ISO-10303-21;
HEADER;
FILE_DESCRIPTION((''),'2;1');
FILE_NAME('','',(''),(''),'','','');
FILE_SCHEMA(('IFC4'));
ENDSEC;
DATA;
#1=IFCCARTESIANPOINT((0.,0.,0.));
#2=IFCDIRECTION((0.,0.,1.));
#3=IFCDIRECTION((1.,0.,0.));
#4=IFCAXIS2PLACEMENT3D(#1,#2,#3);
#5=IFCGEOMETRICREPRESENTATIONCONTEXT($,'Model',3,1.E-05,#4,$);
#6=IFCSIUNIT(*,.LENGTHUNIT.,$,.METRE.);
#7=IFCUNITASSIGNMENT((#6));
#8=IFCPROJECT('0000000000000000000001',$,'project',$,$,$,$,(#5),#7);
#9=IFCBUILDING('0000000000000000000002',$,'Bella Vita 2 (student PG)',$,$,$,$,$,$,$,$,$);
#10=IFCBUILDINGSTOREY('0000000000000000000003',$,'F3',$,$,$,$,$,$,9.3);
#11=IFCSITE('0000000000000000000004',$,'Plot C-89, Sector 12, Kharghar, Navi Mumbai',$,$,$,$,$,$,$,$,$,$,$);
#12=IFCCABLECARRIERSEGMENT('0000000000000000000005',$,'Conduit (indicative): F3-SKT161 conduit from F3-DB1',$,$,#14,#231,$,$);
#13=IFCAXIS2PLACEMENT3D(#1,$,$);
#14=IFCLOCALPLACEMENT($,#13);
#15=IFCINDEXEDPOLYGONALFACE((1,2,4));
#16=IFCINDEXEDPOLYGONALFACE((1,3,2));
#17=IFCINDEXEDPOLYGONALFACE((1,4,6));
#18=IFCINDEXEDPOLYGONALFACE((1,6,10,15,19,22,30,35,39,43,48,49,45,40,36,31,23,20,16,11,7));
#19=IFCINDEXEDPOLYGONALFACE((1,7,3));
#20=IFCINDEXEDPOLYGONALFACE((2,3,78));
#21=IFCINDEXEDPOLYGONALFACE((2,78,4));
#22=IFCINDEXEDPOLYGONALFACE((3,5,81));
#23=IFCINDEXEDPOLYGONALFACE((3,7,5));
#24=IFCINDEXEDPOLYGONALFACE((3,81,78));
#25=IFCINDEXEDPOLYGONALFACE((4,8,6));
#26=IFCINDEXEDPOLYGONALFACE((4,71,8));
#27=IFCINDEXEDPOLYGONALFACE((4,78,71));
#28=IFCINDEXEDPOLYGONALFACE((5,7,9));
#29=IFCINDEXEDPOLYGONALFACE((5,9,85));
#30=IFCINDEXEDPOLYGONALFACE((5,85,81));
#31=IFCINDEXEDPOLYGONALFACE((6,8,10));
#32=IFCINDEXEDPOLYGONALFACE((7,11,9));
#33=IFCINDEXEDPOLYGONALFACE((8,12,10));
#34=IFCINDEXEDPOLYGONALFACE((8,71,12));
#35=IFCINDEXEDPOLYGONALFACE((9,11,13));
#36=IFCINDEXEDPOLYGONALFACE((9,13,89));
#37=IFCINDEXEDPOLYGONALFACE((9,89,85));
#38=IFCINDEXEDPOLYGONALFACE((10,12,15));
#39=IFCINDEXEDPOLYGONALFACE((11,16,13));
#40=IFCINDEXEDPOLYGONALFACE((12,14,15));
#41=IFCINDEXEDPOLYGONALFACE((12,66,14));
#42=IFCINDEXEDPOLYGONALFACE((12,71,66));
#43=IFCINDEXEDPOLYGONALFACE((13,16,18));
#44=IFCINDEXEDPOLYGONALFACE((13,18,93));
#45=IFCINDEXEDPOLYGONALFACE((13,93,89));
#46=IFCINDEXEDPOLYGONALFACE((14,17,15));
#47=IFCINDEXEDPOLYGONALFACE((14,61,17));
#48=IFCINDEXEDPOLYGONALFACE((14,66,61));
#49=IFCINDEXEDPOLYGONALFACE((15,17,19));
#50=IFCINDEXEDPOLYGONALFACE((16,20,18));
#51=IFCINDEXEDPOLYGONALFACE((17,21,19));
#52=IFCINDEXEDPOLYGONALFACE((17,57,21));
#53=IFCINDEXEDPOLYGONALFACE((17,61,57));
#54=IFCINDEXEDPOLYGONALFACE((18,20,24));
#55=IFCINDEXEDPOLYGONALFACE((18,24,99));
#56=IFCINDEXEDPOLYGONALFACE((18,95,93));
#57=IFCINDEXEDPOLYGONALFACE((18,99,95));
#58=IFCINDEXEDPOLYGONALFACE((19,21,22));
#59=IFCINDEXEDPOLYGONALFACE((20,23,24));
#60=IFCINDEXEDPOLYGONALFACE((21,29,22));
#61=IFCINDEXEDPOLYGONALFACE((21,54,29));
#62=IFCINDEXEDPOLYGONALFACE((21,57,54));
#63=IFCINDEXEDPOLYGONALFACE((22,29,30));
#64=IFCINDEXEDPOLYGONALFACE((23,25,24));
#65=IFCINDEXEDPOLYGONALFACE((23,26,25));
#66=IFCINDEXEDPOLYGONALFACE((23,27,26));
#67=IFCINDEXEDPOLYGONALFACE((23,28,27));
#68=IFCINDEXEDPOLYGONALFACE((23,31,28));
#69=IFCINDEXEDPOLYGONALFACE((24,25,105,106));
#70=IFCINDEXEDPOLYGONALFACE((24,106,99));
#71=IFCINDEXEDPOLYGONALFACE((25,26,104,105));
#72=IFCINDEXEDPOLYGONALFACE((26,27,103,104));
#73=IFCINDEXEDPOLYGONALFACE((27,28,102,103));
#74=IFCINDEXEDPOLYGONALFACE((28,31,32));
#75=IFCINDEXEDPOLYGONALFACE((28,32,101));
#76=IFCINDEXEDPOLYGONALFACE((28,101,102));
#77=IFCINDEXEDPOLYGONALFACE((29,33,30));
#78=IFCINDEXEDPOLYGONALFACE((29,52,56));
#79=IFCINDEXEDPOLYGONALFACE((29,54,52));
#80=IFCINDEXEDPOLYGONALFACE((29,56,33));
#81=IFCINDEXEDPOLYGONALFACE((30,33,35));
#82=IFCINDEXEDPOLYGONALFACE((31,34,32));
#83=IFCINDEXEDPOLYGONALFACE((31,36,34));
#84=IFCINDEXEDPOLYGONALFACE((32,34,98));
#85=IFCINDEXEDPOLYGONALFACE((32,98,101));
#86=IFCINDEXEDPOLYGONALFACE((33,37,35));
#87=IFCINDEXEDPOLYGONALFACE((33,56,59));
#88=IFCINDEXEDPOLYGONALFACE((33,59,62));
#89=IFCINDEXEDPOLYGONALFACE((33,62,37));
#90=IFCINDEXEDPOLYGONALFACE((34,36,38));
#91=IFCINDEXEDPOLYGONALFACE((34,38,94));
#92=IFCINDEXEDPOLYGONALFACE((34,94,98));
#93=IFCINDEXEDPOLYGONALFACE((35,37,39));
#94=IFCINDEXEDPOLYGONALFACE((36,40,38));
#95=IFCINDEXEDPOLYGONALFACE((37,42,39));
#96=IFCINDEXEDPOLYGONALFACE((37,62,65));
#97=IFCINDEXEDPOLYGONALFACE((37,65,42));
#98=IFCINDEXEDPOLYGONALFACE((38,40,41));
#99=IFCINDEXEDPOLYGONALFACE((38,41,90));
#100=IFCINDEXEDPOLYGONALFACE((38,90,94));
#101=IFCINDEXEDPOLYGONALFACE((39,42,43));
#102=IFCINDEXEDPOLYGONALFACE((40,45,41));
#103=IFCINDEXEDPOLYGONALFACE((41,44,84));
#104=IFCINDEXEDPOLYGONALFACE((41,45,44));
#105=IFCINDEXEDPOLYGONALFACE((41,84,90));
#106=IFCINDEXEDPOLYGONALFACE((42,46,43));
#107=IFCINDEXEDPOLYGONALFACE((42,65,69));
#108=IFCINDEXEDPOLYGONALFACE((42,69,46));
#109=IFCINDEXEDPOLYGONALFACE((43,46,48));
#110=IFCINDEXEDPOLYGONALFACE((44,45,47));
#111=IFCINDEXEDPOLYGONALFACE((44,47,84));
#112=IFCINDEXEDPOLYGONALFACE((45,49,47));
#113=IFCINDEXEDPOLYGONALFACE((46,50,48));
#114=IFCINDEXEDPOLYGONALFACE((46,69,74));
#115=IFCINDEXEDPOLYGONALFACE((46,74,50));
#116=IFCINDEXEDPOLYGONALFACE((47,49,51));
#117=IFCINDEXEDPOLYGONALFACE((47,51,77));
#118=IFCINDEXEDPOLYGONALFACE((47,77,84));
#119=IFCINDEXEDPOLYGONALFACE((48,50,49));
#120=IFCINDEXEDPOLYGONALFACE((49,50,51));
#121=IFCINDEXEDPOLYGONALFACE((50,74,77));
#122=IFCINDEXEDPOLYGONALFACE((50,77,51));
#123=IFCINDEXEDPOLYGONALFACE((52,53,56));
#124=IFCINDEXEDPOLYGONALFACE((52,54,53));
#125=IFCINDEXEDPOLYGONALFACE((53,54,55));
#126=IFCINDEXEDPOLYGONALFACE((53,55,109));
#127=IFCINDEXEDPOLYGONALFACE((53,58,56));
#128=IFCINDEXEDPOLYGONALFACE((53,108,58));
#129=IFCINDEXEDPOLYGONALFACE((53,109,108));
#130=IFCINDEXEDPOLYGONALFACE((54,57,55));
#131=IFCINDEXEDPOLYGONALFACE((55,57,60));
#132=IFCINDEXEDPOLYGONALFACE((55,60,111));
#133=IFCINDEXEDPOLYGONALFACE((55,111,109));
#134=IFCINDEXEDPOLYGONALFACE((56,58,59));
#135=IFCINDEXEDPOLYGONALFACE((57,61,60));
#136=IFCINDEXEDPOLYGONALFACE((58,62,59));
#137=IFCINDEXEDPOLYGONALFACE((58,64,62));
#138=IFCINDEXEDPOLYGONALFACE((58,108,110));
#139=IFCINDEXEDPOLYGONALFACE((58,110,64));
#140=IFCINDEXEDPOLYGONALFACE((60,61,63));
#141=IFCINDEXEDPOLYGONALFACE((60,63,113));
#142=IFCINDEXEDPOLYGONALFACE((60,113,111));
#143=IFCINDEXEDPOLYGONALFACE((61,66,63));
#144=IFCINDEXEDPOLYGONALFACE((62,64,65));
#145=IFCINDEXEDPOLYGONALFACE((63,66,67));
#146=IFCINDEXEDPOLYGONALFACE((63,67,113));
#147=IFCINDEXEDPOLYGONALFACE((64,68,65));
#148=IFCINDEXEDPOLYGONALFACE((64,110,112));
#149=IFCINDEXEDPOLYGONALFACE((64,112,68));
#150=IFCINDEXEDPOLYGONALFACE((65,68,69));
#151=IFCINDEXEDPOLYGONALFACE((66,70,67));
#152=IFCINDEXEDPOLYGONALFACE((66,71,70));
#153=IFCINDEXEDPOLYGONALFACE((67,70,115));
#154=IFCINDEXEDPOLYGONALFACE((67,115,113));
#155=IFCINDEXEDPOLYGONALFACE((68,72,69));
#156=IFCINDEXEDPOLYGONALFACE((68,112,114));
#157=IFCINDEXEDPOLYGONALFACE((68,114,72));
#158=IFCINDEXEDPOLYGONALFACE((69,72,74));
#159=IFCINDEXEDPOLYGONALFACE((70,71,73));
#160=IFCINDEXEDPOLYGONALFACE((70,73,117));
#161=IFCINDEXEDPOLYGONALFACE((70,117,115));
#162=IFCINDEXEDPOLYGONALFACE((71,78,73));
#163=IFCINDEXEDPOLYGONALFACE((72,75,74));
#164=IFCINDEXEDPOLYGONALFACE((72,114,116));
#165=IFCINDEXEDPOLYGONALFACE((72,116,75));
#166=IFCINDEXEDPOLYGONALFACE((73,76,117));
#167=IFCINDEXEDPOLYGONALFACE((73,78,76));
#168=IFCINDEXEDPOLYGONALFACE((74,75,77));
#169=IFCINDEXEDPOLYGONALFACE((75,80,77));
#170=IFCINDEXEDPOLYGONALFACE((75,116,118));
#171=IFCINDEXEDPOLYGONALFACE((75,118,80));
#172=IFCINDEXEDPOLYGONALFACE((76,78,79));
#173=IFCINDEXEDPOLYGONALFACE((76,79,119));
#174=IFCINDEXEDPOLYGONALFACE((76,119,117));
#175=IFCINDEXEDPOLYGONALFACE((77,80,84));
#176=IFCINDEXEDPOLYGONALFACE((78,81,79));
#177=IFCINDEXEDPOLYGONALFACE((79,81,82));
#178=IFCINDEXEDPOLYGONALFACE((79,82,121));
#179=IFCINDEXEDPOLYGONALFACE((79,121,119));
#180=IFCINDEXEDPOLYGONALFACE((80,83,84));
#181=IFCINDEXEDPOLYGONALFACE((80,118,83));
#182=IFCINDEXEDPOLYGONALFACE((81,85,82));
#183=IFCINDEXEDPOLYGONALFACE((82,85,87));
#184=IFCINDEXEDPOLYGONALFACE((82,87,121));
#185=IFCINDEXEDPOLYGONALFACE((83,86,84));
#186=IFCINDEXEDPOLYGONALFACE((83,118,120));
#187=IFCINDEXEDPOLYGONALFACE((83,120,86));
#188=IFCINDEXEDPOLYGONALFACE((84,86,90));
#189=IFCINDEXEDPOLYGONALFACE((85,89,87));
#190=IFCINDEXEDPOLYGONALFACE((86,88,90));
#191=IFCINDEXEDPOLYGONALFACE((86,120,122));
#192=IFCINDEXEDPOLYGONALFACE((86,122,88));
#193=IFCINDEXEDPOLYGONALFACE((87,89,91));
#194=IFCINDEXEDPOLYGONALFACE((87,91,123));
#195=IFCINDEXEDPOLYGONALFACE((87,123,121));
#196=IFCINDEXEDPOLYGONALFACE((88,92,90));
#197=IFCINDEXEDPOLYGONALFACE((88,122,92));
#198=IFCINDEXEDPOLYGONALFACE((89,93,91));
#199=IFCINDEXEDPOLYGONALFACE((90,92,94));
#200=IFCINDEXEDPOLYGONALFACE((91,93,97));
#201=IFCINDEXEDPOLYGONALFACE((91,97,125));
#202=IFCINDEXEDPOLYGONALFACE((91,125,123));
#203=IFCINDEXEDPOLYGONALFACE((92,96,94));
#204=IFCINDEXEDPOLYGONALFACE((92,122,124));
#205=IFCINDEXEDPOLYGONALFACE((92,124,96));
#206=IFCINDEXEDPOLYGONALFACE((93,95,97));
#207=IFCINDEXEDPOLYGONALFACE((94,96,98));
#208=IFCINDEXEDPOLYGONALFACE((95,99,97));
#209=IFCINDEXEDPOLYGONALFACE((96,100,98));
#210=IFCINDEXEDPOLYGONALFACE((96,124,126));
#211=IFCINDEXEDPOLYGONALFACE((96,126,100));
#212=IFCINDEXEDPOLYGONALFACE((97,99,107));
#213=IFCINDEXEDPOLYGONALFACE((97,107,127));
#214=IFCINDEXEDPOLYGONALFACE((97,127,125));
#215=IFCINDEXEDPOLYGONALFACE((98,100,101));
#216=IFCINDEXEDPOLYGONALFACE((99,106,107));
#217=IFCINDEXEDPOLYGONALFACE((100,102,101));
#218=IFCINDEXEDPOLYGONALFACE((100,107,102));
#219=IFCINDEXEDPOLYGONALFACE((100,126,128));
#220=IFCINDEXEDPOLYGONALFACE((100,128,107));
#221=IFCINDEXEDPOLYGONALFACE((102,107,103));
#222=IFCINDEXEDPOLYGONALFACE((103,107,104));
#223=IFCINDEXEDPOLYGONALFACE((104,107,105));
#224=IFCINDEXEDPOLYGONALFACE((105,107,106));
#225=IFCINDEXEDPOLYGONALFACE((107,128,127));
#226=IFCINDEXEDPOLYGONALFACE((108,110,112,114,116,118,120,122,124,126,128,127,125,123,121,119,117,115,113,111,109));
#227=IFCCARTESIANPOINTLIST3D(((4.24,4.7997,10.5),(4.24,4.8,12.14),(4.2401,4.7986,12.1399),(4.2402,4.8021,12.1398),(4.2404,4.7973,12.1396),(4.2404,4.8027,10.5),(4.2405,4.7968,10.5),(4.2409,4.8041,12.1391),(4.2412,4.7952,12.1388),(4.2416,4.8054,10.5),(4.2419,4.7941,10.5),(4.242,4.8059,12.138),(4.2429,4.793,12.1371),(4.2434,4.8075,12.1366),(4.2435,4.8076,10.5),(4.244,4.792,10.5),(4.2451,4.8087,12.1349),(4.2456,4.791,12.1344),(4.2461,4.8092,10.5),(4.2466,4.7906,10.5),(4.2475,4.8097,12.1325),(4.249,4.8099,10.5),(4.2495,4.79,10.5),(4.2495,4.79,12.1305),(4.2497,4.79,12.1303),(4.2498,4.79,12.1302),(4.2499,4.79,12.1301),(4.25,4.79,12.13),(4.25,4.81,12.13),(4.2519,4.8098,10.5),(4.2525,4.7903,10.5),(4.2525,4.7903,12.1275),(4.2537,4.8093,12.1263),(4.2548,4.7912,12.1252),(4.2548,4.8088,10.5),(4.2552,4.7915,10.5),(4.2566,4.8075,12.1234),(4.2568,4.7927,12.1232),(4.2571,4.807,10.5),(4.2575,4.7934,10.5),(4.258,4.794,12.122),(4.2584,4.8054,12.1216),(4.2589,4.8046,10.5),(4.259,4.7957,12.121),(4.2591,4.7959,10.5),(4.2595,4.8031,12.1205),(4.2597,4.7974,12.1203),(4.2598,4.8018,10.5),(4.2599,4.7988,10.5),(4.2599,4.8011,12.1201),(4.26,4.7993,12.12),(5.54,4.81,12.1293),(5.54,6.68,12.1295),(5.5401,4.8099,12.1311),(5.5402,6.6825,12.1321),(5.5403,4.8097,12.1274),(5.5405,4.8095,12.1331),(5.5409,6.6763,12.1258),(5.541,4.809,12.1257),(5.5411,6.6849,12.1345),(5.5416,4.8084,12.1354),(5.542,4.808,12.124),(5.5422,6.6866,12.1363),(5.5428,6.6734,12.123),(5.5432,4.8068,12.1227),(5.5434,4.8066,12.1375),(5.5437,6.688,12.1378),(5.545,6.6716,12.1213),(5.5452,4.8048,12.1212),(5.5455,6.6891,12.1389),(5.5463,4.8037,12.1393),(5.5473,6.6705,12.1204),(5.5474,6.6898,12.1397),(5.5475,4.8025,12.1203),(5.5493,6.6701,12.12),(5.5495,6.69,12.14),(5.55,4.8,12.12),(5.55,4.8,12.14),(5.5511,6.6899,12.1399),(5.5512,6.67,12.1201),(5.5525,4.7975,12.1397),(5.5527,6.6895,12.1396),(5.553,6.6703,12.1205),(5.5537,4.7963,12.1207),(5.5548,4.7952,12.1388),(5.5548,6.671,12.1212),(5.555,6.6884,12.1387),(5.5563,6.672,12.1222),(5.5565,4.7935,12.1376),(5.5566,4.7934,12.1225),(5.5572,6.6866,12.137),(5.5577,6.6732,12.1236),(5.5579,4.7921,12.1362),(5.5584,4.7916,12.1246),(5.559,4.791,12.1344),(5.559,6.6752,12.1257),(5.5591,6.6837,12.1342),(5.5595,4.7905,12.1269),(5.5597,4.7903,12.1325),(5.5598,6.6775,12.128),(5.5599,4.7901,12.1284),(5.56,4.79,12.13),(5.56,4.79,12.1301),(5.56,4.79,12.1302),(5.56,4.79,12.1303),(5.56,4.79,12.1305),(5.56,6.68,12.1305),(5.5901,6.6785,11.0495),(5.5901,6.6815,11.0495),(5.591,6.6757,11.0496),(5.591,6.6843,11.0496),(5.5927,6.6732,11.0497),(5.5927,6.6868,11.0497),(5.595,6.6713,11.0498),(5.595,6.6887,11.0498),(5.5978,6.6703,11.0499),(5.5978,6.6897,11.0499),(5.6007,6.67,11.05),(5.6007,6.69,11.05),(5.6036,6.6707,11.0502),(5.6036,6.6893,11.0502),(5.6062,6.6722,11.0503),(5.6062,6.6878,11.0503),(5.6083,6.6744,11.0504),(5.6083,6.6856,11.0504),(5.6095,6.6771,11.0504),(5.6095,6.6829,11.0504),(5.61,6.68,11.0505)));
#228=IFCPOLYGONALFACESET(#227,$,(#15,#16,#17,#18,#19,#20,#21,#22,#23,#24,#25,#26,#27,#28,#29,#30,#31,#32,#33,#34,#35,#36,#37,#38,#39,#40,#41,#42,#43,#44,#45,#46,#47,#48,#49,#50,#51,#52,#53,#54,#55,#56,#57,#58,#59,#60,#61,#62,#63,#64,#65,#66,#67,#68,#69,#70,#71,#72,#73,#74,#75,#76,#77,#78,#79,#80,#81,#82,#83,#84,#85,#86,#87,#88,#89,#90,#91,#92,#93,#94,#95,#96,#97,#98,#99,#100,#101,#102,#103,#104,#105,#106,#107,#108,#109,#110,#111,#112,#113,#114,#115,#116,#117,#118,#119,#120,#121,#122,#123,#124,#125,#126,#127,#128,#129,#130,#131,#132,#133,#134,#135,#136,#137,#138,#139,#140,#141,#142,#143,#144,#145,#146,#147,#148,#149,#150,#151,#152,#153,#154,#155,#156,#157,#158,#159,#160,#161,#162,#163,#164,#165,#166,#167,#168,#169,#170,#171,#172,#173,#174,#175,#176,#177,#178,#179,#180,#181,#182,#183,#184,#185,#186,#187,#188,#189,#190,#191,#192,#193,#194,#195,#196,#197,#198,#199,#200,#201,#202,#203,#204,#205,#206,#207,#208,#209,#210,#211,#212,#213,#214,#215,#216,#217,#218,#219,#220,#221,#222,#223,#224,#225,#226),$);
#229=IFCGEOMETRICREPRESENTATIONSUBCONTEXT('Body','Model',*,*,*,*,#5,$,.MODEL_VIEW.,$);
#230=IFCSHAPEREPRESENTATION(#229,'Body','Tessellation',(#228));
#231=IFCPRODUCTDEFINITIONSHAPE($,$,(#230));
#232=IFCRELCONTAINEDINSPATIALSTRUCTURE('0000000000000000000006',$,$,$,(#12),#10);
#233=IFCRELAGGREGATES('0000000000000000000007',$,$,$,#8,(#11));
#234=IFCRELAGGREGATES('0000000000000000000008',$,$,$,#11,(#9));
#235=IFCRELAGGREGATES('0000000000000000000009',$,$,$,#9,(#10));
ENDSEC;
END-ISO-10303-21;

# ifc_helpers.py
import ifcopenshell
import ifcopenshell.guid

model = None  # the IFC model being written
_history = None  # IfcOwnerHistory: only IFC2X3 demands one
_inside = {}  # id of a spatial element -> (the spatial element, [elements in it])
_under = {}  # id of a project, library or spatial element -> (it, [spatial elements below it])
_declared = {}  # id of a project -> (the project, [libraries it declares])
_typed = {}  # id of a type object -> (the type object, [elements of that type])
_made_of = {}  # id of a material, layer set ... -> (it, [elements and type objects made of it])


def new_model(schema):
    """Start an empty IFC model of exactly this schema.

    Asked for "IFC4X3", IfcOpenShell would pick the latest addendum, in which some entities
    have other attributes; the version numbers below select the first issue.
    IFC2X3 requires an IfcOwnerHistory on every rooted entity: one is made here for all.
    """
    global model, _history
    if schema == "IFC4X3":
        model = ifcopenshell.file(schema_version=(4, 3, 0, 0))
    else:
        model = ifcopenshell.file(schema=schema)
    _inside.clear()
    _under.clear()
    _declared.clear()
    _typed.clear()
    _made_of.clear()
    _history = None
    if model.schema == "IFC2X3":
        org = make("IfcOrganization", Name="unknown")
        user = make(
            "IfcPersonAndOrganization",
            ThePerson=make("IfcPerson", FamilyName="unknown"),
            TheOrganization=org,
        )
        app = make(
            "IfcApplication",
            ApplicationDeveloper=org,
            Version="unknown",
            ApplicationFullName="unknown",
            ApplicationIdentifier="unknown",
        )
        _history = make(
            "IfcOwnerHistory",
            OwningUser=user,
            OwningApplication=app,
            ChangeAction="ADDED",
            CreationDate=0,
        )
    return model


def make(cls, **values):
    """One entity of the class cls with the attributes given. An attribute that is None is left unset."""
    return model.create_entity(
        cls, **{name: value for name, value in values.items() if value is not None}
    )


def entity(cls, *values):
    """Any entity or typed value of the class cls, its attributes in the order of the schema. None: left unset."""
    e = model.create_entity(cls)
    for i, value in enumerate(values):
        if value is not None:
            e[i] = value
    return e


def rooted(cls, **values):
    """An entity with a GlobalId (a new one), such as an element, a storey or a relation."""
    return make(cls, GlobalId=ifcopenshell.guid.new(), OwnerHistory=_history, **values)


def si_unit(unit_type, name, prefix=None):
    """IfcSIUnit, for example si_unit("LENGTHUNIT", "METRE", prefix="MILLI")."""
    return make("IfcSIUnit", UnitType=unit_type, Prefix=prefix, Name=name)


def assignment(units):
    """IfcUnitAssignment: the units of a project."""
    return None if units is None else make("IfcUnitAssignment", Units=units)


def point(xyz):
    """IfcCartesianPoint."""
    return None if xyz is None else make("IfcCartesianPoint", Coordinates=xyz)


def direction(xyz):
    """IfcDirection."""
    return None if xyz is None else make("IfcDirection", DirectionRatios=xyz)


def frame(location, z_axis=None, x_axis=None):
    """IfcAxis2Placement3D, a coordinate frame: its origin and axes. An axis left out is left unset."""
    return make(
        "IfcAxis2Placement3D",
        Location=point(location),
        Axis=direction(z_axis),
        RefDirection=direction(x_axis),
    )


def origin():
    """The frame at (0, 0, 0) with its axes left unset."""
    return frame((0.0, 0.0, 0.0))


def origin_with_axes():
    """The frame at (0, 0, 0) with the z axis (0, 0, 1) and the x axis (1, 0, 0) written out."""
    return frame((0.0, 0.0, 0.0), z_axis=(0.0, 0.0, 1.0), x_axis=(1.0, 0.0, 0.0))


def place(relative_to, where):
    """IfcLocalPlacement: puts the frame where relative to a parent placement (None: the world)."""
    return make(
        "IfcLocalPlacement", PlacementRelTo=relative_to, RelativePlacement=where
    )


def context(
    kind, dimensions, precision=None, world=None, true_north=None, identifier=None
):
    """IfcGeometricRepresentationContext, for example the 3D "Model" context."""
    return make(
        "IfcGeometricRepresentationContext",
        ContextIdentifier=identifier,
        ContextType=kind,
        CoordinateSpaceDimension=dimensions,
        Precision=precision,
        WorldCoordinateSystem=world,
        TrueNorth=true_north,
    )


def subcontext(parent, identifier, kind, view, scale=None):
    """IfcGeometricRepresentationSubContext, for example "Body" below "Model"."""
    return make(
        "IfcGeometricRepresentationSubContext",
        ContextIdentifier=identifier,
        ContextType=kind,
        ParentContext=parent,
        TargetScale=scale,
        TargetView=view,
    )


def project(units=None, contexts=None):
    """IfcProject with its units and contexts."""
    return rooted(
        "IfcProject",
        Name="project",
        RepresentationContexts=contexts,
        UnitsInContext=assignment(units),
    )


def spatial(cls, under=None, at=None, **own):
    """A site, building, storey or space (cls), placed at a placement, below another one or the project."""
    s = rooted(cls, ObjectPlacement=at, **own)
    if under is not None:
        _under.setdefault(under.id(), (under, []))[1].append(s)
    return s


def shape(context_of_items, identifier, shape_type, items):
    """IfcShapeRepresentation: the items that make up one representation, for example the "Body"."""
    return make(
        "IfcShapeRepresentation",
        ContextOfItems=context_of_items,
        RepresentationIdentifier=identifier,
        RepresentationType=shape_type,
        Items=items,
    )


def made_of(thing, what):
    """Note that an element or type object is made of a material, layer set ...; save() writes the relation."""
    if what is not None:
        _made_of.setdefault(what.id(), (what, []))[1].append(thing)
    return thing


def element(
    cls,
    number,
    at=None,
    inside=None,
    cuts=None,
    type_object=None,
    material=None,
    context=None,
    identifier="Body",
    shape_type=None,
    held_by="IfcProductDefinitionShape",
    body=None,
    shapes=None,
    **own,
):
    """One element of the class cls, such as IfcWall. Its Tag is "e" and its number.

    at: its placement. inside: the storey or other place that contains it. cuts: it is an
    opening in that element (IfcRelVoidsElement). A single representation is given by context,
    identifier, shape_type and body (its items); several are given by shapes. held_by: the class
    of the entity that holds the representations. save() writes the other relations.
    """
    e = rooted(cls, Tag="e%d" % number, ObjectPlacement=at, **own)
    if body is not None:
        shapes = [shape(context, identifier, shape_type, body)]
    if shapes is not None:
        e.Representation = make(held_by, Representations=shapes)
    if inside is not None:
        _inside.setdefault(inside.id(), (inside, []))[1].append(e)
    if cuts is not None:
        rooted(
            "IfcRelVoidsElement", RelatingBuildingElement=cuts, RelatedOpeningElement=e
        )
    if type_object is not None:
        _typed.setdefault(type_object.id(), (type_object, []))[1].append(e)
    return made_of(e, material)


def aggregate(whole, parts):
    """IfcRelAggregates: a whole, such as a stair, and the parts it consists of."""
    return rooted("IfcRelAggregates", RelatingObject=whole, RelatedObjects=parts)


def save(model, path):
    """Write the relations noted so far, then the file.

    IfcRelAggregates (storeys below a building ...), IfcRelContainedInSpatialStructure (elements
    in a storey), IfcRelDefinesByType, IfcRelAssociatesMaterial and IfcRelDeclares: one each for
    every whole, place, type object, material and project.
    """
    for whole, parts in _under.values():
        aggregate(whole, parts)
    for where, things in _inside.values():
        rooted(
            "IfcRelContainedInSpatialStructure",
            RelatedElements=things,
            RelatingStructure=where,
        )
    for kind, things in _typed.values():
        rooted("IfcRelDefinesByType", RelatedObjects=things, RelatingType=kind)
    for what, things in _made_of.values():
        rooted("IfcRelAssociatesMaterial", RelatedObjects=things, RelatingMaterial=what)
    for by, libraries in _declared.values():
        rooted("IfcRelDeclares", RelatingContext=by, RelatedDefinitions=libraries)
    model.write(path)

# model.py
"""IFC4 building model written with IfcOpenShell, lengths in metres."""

from ifc_helpers import new_model, entity, si_unit, origin, origin_with_axes, place, context, subcontext, project, spatial, element, save


model = new_model("IFC4")

# Units and contexts
model_context = context("Model", 3, precision=1e-05, world=origin_with_axes())
body_context = subcontext(model_context, "Body", "Model", "MODEL_VIEW")
ifc_project = project(units=[si_unit("LENGTHUNIT", "METRE")], contexts=[model_context])

# Site, building, storey
site = spatial("IfcSite", under=ifc_project, Name="Plot C-89, Sector 12, Kharghar, Navi Mumbai")
building = spatial("IfcBuilding", under=site, Name="Bella Vita 2 (student PG)")
storey = spatial("IfcBuildingStorey", under=building, Name="F3", Elevation=9.3)

# Cable carrier segment
cable_carrier_segment_1_placement = place(None, origin())
element("IfcCableCarrierSegment", 1, at=cable_carrier_segment_1_placement, inside=storey, Name="Conduit (indicative): F3-SKT161 conduit from F3-DB1", context=body_context, shape_type="AdvancedSweptSolid", body=[
    entity("IfcSweptDiskSolid", entity("IfcPolyline", [entity("IfcCartesianPoint", [5.6, 6.68, 11.05]), entity("IfcCartesianPoint", [5.55, 6.68, 12.13]), entity("IfcCartesianPoint", [5.55, 4.8, 12.13]), entity("IfcCartesianPoint", [4.25, 4.8, 12.13]), entity("IfcCartesianPoint", [4.25, 4.8, 10.5])]), 0.01),
])

save(model, "model.ifc")
